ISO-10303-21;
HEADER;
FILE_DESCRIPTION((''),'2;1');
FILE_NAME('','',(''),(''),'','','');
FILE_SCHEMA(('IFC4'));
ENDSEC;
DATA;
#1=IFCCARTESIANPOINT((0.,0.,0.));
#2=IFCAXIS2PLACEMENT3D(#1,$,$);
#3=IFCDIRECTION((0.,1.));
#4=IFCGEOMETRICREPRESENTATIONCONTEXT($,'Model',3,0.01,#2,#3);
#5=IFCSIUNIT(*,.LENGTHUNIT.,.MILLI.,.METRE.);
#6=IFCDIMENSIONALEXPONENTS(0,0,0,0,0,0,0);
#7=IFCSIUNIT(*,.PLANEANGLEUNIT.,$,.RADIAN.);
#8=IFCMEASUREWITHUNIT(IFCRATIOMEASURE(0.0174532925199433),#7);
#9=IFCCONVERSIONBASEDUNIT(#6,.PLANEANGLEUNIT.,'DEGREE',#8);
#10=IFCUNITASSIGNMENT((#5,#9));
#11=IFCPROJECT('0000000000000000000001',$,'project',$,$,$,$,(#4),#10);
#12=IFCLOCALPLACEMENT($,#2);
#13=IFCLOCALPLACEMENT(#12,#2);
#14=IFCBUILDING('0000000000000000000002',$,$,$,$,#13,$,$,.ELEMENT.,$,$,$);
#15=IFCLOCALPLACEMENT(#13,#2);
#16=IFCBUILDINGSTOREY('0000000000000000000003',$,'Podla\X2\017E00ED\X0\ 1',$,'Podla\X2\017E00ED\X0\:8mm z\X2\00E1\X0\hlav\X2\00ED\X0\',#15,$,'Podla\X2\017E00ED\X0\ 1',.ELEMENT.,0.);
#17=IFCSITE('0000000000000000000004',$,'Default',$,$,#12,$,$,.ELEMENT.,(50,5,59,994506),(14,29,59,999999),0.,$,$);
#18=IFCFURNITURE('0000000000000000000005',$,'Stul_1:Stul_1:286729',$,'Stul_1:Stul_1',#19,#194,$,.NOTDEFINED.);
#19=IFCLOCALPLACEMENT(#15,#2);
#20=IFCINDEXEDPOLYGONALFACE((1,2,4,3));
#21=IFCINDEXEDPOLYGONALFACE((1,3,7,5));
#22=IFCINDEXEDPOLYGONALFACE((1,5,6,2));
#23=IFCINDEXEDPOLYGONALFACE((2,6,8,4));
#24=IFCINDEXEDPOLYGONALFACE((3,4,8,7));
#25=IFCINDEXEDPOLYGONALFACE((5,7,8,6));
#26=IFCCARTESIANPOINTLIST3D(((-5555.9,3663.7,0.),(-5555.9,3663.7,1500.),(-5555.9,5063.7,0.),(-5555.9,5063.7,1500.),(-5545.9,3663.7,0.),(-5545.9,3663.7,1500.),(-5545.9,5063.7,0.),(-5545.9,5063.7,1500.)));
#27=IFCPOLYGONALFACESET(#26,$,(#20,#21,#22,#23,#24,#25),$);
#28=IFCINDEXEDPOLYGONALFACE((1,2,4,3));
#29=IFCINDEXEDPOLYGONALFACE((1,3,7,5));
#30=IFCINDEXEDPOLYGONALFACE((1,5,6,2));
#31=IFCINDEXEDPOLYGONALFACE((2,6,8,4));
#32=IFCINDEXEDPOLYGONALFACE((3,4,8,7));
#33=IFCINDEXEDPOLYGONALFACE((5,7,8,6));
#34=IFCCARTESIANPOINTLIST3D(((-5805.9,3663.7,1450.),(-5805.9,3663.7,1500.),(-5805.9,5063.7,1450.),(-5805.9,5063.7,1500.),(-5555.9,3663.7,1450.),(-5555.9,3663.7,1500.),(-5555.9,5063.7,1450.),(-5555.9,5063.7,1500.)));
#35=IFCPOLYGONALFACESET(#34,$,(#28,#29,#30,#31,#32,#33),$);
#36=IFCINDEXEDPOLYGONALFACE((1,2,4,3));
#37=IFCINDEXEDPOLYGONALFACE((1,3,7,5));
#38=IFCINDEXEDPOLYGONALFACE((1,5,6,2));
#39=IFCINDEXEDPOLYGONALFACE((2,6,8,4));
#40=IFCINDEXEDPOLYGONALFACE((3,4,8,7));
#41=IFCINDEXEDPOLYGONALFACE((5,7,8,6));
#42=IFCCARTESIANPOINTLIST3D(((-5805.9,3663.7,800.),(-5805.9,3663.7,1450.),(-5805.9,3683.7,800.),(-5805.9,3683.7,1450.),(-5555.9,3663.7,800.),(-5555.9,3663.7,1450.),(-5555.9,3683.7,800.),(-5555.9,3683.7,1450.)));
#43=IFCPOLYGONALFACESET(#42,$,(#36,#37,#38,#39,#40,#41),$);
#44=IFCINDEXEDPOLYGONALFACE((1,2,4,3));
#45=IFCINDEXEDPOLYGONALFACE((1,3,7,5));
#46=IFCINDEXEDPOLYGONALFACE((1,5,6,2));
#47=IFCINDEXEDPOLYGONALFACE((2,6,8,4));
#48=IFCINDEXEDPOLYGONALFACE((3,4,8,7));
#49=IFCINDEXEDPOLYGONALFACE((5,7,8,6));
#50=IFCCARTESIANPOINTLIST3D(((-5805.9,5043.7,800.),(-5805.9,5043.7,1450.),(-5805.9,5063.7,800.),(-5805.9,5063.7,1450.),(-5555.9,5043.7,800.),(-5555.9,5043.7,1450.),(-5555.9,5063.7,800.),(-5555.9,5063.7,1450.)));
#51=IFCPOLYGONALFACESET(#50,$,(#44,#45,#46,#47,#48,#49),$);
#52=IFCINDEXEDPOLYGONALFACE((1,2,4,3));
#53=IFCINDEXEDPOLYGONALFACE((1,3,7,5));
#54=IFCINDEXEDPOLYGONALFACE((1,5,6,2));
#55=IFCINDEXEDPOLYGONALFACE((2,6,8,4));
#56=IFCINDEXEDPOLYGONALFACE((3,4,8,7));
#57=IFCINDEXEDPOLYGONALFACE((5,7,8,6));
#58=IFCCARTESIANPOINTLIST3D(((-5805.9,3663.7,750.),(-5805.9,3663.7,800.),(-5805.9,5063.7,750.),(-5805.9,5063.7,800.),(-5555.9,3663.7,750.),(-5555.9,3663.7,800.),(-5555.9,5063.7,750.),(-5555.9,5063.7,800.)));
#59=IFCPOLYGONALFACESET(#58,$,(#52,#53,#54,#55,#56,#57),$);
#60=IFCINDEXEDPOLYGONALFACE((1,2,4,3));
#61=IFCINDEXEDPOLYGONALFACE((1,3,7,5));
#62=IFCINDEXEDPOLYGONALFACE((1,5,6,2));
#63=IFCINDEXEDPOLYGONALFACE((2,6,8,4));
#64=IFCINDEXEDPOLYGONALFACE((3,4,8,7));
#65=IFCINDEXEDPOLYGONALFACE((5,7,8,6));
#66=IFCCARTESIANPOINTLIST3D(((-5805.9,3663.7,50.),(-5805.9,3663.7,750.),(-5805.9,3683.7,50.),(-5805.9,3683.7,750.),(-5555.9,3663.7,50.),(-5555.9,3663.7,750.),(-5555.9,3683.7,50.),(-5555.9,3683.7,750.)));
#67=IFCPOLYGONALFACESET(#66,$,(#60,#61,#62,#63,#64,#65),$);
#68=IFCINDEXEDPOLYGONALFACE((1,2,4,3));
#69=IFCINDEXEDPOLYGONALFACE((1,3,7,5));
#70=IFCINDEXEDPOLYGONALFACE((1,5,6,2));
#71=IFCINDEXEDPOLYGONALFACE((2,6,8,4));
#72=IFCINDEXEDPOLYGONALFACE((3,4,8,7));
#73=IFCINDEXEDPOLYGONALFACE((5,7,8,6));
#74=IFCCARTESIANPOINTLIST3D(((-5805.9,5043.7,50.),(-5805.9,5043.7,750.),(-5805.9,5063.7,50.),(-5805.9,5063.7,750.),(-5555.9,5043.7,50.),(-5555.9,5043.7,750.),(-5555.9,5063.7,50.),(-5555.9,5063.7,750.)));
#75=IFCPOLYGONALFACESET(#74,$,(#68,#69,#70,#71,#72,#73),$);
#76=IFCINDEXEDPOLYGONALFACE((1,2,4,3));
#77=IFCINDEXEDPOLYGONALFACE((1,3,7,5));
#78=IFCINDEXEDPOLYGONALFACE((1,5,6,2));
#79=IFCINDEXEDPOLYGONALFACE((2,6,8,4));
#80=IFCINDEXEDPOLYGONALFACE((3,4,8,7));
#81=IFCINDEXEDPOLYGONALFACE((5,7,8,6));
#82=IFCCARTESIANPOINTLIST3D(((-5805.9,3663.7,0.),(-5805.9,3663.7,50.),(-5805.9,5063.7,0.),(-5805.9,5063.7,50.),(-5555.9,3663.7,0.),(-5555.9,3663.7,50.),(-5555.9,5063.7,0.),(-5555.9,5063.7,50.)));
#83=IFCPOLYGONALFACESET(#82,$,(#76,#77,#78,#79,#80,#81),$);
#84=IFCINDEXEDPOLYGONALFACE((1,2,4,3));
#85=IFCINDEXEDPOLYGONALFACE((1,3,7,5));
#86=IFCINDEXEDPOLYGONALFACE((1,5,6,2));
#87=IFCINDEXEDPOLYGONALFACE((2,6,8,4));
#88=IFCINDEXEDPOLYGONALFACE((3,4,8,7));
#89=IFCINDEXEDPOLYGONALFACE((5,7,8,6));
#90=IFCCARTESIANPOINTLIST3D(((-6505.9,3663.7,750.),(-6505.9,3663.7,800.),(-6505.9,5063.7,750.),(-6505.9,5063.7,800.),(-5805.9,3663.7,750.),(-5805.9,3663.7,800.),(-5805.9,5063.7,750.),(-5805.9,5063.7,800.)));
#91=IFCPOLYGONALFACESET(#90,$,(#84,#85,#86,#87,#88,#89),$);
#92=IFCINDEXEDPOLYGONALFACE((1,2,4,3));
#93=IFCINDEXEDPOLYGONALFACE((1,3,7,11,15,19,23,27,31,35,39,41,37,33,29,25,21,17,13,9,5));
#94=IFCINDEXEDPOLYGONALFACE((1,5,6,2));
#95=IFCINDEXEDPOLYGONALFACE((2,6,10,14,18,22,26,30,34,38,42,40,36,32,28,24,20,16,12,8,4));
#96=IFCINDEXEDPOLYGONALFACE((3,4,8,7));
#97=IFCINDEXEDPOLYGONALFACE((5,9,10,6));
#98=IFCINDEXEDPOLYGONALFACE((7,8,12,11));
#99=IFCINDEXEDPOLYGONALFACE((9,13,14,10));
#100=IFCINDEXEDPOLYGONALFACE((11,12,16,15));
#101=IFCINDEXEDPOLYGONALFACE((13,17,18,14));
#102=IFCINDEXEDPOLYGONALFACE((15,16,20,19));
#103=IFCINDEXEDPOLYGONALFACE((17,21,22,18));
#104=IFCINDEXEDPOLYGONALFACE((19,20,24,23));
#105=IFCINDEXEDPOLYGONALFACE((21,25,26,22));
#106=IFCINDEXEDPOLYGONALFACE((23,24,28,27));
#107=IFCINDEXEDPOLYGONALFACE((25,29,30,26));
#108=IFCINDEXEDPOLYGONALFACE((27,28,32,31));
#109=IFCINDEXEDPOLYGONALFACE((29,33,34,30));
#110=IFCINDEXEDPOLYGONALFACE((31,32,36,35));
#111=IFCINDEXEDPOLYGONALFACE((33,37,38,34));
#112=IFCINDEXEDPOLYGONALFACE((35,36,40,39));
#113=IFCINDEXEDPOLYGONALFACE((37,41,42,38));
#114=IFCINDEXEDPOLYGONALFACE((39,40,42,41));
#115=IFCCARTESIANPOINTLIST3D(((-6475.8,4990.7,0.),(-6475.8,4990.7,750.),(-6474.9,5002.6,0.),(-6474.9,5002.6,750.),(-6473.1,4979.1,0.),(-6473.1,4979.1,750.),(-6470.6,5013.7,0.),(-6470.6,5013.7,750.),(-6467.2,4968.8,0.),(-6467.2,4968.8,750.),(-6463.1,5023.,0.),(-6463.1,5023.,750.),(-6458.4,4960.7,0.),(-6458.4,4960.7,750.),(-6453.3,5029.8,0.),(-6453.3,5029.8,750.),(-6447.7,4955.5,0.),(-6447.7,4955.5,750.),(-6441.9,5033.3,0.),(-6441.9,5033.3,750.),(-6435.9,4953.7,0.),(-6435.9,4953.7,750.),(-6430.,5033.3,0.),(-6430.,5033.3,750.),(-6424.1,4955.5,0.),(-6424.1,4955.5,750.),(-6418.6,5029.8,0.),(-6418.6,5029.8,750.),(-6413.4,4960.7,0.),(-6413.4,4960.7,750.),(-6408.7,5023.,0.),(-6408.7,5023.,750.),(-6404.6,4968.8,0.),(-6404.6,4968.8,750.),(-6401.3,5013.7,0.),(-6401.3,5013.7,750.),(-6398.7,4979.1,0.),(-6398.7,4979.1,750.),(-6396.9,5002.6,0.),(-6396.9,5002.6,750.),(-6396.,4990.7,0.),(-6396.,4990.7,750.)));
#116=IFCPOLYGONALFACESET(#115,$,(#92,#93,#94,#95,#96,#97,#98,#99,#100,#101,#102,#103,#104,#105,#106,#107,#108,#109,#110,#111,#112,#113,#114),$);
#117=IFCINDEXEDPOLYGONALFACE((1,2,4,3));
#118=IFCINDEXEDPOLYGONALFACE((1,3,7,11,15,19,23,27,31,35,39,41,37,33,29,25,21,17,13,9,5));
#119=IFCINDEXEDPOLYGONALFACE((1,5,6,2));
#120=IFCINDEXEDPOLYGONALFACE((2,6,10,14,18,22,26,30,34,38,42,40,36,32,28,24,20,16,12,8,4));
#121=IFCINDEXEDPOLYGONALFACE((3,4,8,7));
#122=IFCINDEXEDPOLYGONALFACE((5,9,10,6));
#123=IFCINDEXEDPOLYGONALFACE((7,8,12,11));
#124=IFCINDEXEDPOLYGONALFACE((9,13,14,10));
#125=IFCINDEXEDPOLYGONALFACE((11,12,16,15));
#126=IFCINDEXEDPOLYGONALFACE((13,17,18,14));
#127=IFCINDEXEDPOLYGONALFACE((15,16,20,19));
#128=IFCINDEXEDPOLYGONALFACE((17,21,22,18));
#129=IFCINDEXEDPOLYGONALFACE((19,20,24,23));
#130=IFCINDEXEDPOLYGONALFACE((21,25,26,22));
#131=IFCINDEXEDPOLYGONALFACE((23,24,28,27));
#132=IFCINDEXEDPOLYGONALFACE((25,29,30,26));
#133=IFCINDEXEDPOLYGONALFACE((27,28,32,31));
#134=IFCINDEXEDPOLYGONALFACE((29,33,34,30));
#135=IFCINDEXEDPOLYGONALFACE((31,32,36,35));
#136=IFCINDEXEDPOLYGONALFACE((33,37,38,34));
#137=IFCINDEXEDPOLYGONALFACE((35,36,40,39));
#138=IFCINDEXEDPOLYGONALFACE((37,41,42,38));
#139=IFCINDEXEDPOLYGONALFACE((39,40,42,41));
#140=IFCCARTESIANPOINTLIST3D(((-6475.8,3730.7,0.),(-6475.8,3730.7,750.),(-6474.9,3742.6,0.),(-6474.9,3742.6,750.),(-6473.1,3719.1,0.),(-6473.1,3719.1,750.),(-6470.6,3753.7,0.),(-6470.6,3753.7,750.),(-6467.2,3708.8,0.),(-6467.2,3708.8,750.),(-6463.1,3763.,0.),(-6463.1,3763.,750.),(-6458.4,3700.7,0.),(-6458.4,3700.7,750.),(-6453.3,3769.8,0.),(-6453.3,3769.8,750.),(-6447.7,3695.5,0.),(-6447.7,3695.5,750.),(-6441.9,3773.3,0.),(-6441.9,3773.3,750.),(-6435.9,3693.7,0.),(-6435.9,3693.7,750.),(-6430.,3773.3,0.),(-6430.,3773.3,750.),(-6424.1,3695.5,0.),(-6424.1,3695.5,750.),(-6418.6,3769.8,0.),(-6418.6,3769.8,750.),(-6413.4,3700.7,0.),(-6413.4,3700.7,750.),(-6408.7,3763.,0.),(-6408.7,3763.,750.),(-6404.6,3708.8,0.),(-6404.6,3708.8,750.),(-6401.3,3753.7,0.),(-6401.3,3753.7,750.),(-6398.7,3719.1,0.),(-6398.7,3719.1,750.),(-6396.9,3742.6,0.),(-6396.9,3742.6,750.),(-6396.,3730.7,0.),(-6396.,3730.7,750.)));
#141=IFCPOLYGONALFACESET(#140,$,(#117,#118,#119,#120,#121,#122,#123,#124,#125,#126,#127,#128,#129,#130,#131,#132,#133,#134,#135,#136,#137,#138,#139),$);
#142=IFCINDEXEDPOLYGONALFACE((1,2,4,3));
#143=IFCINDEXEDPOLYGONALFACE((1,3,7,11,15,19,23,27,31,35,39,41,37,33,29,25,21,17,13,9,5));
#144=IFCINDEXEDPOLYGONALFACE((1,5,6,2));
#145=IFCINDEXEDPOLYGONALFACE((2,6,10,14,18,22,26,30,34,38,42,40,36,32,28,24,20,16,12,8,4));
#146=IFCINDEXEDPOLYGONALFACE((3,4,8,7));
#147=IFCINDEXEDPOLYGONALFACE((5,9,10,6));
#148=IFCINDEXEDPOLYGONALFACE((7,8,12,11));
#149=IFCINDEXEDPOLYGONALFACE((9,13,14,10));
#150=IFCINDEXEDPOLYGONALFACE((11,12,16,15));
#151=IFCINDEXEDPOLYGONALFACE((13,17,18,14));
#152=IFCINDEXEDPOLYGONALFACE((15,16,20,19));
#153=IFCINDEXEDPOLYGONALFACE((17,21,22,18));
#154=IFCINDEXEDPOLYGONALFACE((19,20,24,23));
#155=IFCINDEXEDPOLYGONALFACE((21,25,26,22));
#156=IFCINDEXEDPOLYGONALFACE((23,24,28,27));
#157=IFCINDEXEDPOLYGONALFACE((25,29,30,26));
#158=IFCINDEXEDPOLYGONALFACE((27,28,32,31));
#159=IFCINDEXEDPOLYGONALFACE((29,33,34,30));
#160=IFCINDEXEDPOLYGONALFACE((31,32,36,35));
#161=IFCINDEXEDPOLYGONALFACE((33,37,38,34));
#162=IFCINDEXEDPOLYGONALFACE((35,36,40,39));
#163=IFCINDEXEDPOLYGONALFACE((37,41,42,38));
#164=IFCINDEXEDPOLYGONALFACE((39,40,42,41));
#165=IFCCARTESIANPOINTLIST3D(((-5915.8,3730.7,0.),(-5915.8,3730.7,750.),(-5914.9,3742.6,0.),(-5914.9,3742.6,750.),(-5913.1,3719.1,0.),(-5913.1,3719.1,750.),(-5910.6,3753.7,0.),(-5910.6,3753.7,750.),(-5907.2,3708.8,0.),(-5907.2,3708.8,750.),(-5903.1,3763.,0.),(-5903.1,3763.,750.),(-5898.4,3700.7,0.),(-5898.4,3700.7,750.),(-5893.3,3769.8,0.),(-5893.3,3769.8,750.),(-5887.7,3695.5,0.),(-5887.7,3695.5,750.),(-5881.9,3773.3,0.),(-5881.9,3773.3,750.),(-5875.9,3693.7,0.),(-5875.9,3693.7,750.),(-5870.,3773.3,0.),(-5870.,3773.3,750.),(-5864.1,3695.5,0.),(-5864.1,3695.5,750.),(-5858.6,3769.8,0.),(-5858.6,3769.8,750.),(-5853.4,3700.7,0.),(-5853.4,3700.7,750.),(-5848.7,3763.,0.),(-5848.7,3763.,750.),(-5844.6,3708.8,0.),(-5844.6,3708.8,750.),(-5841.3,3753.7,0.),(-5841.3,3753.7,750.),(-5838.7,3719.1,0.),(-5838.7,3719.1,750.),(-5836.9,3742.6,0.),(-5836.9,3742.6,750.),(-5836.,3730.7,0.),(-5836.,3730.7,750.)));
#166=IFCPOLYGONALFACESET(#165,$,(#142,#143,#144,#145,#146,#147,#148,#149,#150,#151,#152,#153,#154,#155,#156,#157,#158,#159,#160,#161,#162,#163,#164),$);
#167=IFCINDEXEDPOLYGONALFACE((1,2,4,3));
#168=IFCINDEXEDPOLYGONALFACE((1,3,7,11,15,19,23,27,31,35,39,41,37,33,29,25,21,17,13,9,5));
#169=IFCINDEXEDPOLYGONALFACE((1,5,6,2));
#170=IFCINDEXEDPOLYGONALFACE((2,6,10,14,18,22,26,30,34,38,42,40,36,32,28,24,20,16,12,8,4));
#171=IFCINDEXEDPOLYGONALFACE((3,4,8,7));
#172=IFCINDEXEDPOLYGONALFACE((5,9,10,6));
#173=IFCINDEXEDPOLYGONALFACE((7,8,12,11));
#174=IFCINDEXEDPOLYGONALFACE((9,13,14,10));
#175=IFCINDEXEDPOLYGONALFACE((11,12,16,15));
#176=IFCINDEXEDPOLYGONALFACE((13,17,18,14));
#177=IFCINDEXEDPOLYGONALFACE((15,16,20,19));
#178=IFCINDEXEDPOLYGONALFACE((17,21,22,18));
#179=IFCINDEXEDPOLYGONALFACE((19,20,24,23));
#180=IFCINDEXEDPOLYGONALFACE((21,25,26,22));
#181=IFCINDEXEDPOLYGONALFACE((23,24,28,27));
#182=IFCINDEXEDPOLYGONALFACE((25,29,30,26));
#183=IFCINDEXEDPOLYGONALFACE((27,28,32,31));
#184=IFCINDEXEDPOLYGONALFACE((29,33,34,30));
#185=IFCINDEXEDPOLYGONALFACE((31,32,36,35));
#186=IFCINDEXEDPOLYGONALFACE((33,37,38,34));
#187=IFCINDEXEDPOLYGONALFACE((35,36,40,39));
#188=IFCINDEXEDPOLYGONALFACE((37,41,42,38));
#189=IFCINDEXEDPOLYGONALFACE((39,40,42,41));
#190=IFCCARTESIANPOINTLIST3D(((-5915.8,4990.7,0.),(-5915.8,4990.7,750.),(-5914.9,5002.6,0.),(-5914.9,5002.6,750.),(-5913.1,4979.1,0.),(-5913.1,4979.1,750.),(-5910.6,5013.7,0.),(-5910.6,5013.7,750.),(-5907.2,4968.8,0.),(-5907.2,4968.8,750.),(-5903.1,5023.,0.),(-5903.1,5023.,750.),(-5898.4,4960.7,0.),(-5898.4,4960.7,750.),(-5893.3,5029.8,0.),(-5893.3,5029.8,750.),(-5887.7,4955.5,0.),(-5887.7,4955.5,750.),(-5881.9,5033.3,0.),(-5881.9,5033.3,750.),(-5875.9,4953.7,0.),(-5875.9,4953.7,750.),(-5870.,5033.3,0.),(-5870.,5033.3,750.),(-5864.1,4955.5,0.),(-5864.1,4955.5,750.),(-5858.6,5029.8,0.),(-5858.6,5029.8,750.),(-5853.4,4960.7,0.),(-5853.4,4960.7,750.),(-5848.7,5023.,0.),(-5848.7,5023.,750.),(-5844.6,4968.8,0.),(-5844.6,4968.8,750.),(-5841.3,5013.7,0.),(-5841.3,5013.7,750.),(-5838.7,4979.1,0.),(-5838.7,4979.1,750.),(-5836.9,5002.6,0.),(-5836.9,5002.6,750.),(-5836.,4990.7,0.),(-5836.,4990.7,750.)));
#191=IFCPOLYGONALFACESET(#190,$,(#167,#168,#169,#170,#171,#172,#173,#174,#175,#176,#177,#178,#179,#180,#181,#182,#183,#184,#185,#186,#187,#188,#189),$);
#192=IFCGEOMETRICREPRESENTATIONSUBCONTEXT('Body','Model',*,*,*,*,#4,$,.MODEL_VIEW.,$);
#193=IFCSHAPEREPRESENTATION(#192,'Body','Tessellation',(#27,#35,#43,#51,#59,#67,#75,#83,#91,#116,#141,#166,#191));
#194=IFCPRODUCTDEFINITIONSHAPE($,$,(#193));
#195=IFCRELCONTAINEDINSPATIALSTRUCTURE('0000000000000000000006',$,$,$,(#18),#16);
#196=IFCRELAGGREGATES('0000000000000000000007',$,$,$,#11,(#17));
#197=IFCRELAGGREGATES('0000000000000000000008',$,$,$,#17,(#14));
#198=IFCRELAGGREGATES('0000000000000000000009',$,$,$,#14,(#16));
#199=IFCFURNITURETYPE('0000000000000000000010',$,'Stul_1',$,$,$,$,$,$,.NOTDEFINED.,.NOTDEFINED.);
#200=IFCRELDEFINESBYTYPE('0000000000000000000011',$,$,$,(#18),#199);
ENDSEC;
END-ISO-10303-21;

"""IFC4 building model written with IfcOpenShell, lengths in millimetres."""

from ifc_helpers import new_model, entity, si_unit, converted_unit, direction, frame, frame_2d, origin, origin_2d_with_axis, place, context, subcontext, project, spatial, rectangle, circle, extrude, source, transform, mapped, type_object, type_shapes, element, save


model = new_model("IFC4")

# Units and contexts
model_context = context("Model", 3, precision=0.01, world=origin(), true_north=direction((0.0, 1.0)))
body_context = subcontext(model_context, "Body", "Model", "MODEL_VIEW")
ifc_project = project(units=[si_unit("LENGTHUNIT", "METRE", prefix="MILLI"), converted_unit("PLANEANGLEUNIT", "DEGREE", entity("IfcRatioMeasure", 0.0174532925199433), si_unit("PLANEANGLEUNIT", "RADIAN"), dimensions=[0, 0, 0, 0, 0, 0, 0])], contexts=[model_context])

# Site, building, storey
site_placement = place(None, origin())
site = spatial("IfcSite", under=ifc_project, at=site_placement, Name="Default", CompositionType="ELEMENT", RefLatitude=(50, 5, 59, 994506), RefLongitude=(14, 29, 59, 999999), RefElevation=0.0)
building_placement = place(site_placement, origin())
building = spatial("IfcBuilding", under=site, at=building_placement, CompositionType="ELEMENT")
storey_placement = place(building_placement, origin())
storey = spatial("IfcBuildingStorey", under=building, at=storey_placement, Name="Podlaží 1", ObjectType="Podlaží:8mm záhlaví", LongName="Podlaží 1", CompositionType="ELEMENT", Elevation=0.0)

# Furniture
furniture_type = type_object("IfcFurnitureType", Name="Stul_1", AssemblyPlace="NOTDEFINED", PredefinedType="NOTDEFINED")
shared_shape_1 = source(origin(), body_context, "Body", "SweptSolid", [
    extrude(rectangle(XDim=1400.0, YDim=10.0, at=origin_2d_with_axis()), frame((0.0, 605.0, 0.0), z_axis=(0.0, 0.0, 1.0), x_axis=(-1.0, 0.0, 0.0)), (0.0, 0.0, 1.0), 1500.0),
    extrude(rectangle(XDim=1400.0, YDim=250.0, at=frame_2d((0.0, 0.0), x_axis=(1.0, 0.0))), frame((0.0, 475.0, 1450.0), z_axis=(0.0, 0.0, 1.0), x_axis=(-1.0, 0.0, 0.0)), (0.0, 0.0, 1.0), 50.0),
    extrude(rectangle(XDim=20.0, YDim=250.0, at=origin_2d_with_axis()), frame((690.0, 475.0, 800.0), z_axis=(0.0, 0.0, 1.0), x_axis=(-1.0, 0.0, 0.0)), (0.0, 0.0, 1.0), 650.0),
    extrude(rectangle(XDim=20.0, YDim=250.0, at=frame_2d((0.0, 0.0), x_axis=(1.0, 0.0))), frame((-690.0, 475.0, 800.0), z_axis=(0.0, 0.0, 1.0), x_axis=(-1.0, 0.0, 0.0)), (0.0, 0.0, 1.0), 650.0),
    extrude(rectangle(XDim=1400.0, YDim=250.0, at=origin_2d_with_axis()), frame((0.0, 475.0, 750.0), z_axis=(0.0, 0.0, 1.0), x_axis=(-1.0, 0.0, 0.0)), (0.0, 0.0, 1.0), 50.0),
    extrude(rectangle(XDim=20.0, YDim=250.0, at=origin_2d_with_axis()), frame((690.0, 475.0, 50.0), z_axis=(0.0, 0.0, 1.0), x_axis=(-1.0, 0.0, 0.0)), (0.0, 0.0, 1.0), 700.0),
    extrude(rectangle(XDim=20.0, YDim=250.0, at=frame_2d((0.0, 0.0), x_axis=(1.0, 0.0))), frame((-690.0, 475.0, 50.0), z_axis=(0.0, 0.0, 1.0), x_axis=(-1.0, 0.0, 0.0)), (0.0, 0.0, 1.0), 700.0),
    extrude(rectangle(XDim=1400.0, YDim=250.0, at=origin_2d_with_axis()), frame((0.0, 475.0, 0.0), z_axis=(0.0, 0.0, 1.0), x_axis=(-1.0, 0.0, 0.0)), (0.0, 0.0, 1.0), 50.0),
    extrude(rectangle(XDim=1400.0, YDim=700.0, at=origin_2d_with_axis()), frame((0.0, 0.0, 750.0), z_axis=(0.0, 0.0, 1.0), x_axis=(-1.0, 0.0, 0.0)), (0.0, 0.0, 1.0), 50.0),
    extrude(circle(Radius=40.0, at=frame_2d((0.0, 0.0), x_axis=(1.0, 0.0))), frame((-630.0, -280.0, 0.0)), (0.0, 0.0, 1.0), 750.0),
    extrude(circle(Radius=40.0, at=frame_2d((0.0, 0.0), x_axis=(1.0, 0.0))), frame((630.0, -280.0, 0.0)), (0.0, 0.0, 1.0), 750.0),
    extrude(circle(Radius=40.0, at=frame_2d((0.0, 0.0), x_axis=(1.0, 0.0))), frame((630.0, 280.0, 0.0)), (0.0, 0.0, 1.0), 750.0),
    extrude(circle(Radius=40.0, at=frame_2d((0.0, 0.0), x_axis=(1.0, 0.0))), frame((-630.0, 280.0, 0.0)), (0.0, 0.0, 1.0), 750.0),
])
type_shapes(furniture_type, [shared_shape_1])
for number, where, z_axis, x_axis, name in (
    (1, (-6155.9, 4363.7, 0.0), (0.0, 0.0, 1.0), (0.0, -1.0, 0.0), "Stul_1:Stul_1:286729"),
):
    element("IfcFurniture", number, at=place(storey_placement, frame(where, z_axis=z_axis, x_axis=x_axis)), inside=storey, type_object=furniture_type, Name=name, ObjectType="Stul_1:Stul_1", PredefinedType="NOTDEFINED", context=body_context, shape_type="MappedRepresentation", body=[
        mapped(shared_shape_1, transform((0.0, 0.0, 0.0), scale=1.0)),
    ])

save(model, "model.ifc")
